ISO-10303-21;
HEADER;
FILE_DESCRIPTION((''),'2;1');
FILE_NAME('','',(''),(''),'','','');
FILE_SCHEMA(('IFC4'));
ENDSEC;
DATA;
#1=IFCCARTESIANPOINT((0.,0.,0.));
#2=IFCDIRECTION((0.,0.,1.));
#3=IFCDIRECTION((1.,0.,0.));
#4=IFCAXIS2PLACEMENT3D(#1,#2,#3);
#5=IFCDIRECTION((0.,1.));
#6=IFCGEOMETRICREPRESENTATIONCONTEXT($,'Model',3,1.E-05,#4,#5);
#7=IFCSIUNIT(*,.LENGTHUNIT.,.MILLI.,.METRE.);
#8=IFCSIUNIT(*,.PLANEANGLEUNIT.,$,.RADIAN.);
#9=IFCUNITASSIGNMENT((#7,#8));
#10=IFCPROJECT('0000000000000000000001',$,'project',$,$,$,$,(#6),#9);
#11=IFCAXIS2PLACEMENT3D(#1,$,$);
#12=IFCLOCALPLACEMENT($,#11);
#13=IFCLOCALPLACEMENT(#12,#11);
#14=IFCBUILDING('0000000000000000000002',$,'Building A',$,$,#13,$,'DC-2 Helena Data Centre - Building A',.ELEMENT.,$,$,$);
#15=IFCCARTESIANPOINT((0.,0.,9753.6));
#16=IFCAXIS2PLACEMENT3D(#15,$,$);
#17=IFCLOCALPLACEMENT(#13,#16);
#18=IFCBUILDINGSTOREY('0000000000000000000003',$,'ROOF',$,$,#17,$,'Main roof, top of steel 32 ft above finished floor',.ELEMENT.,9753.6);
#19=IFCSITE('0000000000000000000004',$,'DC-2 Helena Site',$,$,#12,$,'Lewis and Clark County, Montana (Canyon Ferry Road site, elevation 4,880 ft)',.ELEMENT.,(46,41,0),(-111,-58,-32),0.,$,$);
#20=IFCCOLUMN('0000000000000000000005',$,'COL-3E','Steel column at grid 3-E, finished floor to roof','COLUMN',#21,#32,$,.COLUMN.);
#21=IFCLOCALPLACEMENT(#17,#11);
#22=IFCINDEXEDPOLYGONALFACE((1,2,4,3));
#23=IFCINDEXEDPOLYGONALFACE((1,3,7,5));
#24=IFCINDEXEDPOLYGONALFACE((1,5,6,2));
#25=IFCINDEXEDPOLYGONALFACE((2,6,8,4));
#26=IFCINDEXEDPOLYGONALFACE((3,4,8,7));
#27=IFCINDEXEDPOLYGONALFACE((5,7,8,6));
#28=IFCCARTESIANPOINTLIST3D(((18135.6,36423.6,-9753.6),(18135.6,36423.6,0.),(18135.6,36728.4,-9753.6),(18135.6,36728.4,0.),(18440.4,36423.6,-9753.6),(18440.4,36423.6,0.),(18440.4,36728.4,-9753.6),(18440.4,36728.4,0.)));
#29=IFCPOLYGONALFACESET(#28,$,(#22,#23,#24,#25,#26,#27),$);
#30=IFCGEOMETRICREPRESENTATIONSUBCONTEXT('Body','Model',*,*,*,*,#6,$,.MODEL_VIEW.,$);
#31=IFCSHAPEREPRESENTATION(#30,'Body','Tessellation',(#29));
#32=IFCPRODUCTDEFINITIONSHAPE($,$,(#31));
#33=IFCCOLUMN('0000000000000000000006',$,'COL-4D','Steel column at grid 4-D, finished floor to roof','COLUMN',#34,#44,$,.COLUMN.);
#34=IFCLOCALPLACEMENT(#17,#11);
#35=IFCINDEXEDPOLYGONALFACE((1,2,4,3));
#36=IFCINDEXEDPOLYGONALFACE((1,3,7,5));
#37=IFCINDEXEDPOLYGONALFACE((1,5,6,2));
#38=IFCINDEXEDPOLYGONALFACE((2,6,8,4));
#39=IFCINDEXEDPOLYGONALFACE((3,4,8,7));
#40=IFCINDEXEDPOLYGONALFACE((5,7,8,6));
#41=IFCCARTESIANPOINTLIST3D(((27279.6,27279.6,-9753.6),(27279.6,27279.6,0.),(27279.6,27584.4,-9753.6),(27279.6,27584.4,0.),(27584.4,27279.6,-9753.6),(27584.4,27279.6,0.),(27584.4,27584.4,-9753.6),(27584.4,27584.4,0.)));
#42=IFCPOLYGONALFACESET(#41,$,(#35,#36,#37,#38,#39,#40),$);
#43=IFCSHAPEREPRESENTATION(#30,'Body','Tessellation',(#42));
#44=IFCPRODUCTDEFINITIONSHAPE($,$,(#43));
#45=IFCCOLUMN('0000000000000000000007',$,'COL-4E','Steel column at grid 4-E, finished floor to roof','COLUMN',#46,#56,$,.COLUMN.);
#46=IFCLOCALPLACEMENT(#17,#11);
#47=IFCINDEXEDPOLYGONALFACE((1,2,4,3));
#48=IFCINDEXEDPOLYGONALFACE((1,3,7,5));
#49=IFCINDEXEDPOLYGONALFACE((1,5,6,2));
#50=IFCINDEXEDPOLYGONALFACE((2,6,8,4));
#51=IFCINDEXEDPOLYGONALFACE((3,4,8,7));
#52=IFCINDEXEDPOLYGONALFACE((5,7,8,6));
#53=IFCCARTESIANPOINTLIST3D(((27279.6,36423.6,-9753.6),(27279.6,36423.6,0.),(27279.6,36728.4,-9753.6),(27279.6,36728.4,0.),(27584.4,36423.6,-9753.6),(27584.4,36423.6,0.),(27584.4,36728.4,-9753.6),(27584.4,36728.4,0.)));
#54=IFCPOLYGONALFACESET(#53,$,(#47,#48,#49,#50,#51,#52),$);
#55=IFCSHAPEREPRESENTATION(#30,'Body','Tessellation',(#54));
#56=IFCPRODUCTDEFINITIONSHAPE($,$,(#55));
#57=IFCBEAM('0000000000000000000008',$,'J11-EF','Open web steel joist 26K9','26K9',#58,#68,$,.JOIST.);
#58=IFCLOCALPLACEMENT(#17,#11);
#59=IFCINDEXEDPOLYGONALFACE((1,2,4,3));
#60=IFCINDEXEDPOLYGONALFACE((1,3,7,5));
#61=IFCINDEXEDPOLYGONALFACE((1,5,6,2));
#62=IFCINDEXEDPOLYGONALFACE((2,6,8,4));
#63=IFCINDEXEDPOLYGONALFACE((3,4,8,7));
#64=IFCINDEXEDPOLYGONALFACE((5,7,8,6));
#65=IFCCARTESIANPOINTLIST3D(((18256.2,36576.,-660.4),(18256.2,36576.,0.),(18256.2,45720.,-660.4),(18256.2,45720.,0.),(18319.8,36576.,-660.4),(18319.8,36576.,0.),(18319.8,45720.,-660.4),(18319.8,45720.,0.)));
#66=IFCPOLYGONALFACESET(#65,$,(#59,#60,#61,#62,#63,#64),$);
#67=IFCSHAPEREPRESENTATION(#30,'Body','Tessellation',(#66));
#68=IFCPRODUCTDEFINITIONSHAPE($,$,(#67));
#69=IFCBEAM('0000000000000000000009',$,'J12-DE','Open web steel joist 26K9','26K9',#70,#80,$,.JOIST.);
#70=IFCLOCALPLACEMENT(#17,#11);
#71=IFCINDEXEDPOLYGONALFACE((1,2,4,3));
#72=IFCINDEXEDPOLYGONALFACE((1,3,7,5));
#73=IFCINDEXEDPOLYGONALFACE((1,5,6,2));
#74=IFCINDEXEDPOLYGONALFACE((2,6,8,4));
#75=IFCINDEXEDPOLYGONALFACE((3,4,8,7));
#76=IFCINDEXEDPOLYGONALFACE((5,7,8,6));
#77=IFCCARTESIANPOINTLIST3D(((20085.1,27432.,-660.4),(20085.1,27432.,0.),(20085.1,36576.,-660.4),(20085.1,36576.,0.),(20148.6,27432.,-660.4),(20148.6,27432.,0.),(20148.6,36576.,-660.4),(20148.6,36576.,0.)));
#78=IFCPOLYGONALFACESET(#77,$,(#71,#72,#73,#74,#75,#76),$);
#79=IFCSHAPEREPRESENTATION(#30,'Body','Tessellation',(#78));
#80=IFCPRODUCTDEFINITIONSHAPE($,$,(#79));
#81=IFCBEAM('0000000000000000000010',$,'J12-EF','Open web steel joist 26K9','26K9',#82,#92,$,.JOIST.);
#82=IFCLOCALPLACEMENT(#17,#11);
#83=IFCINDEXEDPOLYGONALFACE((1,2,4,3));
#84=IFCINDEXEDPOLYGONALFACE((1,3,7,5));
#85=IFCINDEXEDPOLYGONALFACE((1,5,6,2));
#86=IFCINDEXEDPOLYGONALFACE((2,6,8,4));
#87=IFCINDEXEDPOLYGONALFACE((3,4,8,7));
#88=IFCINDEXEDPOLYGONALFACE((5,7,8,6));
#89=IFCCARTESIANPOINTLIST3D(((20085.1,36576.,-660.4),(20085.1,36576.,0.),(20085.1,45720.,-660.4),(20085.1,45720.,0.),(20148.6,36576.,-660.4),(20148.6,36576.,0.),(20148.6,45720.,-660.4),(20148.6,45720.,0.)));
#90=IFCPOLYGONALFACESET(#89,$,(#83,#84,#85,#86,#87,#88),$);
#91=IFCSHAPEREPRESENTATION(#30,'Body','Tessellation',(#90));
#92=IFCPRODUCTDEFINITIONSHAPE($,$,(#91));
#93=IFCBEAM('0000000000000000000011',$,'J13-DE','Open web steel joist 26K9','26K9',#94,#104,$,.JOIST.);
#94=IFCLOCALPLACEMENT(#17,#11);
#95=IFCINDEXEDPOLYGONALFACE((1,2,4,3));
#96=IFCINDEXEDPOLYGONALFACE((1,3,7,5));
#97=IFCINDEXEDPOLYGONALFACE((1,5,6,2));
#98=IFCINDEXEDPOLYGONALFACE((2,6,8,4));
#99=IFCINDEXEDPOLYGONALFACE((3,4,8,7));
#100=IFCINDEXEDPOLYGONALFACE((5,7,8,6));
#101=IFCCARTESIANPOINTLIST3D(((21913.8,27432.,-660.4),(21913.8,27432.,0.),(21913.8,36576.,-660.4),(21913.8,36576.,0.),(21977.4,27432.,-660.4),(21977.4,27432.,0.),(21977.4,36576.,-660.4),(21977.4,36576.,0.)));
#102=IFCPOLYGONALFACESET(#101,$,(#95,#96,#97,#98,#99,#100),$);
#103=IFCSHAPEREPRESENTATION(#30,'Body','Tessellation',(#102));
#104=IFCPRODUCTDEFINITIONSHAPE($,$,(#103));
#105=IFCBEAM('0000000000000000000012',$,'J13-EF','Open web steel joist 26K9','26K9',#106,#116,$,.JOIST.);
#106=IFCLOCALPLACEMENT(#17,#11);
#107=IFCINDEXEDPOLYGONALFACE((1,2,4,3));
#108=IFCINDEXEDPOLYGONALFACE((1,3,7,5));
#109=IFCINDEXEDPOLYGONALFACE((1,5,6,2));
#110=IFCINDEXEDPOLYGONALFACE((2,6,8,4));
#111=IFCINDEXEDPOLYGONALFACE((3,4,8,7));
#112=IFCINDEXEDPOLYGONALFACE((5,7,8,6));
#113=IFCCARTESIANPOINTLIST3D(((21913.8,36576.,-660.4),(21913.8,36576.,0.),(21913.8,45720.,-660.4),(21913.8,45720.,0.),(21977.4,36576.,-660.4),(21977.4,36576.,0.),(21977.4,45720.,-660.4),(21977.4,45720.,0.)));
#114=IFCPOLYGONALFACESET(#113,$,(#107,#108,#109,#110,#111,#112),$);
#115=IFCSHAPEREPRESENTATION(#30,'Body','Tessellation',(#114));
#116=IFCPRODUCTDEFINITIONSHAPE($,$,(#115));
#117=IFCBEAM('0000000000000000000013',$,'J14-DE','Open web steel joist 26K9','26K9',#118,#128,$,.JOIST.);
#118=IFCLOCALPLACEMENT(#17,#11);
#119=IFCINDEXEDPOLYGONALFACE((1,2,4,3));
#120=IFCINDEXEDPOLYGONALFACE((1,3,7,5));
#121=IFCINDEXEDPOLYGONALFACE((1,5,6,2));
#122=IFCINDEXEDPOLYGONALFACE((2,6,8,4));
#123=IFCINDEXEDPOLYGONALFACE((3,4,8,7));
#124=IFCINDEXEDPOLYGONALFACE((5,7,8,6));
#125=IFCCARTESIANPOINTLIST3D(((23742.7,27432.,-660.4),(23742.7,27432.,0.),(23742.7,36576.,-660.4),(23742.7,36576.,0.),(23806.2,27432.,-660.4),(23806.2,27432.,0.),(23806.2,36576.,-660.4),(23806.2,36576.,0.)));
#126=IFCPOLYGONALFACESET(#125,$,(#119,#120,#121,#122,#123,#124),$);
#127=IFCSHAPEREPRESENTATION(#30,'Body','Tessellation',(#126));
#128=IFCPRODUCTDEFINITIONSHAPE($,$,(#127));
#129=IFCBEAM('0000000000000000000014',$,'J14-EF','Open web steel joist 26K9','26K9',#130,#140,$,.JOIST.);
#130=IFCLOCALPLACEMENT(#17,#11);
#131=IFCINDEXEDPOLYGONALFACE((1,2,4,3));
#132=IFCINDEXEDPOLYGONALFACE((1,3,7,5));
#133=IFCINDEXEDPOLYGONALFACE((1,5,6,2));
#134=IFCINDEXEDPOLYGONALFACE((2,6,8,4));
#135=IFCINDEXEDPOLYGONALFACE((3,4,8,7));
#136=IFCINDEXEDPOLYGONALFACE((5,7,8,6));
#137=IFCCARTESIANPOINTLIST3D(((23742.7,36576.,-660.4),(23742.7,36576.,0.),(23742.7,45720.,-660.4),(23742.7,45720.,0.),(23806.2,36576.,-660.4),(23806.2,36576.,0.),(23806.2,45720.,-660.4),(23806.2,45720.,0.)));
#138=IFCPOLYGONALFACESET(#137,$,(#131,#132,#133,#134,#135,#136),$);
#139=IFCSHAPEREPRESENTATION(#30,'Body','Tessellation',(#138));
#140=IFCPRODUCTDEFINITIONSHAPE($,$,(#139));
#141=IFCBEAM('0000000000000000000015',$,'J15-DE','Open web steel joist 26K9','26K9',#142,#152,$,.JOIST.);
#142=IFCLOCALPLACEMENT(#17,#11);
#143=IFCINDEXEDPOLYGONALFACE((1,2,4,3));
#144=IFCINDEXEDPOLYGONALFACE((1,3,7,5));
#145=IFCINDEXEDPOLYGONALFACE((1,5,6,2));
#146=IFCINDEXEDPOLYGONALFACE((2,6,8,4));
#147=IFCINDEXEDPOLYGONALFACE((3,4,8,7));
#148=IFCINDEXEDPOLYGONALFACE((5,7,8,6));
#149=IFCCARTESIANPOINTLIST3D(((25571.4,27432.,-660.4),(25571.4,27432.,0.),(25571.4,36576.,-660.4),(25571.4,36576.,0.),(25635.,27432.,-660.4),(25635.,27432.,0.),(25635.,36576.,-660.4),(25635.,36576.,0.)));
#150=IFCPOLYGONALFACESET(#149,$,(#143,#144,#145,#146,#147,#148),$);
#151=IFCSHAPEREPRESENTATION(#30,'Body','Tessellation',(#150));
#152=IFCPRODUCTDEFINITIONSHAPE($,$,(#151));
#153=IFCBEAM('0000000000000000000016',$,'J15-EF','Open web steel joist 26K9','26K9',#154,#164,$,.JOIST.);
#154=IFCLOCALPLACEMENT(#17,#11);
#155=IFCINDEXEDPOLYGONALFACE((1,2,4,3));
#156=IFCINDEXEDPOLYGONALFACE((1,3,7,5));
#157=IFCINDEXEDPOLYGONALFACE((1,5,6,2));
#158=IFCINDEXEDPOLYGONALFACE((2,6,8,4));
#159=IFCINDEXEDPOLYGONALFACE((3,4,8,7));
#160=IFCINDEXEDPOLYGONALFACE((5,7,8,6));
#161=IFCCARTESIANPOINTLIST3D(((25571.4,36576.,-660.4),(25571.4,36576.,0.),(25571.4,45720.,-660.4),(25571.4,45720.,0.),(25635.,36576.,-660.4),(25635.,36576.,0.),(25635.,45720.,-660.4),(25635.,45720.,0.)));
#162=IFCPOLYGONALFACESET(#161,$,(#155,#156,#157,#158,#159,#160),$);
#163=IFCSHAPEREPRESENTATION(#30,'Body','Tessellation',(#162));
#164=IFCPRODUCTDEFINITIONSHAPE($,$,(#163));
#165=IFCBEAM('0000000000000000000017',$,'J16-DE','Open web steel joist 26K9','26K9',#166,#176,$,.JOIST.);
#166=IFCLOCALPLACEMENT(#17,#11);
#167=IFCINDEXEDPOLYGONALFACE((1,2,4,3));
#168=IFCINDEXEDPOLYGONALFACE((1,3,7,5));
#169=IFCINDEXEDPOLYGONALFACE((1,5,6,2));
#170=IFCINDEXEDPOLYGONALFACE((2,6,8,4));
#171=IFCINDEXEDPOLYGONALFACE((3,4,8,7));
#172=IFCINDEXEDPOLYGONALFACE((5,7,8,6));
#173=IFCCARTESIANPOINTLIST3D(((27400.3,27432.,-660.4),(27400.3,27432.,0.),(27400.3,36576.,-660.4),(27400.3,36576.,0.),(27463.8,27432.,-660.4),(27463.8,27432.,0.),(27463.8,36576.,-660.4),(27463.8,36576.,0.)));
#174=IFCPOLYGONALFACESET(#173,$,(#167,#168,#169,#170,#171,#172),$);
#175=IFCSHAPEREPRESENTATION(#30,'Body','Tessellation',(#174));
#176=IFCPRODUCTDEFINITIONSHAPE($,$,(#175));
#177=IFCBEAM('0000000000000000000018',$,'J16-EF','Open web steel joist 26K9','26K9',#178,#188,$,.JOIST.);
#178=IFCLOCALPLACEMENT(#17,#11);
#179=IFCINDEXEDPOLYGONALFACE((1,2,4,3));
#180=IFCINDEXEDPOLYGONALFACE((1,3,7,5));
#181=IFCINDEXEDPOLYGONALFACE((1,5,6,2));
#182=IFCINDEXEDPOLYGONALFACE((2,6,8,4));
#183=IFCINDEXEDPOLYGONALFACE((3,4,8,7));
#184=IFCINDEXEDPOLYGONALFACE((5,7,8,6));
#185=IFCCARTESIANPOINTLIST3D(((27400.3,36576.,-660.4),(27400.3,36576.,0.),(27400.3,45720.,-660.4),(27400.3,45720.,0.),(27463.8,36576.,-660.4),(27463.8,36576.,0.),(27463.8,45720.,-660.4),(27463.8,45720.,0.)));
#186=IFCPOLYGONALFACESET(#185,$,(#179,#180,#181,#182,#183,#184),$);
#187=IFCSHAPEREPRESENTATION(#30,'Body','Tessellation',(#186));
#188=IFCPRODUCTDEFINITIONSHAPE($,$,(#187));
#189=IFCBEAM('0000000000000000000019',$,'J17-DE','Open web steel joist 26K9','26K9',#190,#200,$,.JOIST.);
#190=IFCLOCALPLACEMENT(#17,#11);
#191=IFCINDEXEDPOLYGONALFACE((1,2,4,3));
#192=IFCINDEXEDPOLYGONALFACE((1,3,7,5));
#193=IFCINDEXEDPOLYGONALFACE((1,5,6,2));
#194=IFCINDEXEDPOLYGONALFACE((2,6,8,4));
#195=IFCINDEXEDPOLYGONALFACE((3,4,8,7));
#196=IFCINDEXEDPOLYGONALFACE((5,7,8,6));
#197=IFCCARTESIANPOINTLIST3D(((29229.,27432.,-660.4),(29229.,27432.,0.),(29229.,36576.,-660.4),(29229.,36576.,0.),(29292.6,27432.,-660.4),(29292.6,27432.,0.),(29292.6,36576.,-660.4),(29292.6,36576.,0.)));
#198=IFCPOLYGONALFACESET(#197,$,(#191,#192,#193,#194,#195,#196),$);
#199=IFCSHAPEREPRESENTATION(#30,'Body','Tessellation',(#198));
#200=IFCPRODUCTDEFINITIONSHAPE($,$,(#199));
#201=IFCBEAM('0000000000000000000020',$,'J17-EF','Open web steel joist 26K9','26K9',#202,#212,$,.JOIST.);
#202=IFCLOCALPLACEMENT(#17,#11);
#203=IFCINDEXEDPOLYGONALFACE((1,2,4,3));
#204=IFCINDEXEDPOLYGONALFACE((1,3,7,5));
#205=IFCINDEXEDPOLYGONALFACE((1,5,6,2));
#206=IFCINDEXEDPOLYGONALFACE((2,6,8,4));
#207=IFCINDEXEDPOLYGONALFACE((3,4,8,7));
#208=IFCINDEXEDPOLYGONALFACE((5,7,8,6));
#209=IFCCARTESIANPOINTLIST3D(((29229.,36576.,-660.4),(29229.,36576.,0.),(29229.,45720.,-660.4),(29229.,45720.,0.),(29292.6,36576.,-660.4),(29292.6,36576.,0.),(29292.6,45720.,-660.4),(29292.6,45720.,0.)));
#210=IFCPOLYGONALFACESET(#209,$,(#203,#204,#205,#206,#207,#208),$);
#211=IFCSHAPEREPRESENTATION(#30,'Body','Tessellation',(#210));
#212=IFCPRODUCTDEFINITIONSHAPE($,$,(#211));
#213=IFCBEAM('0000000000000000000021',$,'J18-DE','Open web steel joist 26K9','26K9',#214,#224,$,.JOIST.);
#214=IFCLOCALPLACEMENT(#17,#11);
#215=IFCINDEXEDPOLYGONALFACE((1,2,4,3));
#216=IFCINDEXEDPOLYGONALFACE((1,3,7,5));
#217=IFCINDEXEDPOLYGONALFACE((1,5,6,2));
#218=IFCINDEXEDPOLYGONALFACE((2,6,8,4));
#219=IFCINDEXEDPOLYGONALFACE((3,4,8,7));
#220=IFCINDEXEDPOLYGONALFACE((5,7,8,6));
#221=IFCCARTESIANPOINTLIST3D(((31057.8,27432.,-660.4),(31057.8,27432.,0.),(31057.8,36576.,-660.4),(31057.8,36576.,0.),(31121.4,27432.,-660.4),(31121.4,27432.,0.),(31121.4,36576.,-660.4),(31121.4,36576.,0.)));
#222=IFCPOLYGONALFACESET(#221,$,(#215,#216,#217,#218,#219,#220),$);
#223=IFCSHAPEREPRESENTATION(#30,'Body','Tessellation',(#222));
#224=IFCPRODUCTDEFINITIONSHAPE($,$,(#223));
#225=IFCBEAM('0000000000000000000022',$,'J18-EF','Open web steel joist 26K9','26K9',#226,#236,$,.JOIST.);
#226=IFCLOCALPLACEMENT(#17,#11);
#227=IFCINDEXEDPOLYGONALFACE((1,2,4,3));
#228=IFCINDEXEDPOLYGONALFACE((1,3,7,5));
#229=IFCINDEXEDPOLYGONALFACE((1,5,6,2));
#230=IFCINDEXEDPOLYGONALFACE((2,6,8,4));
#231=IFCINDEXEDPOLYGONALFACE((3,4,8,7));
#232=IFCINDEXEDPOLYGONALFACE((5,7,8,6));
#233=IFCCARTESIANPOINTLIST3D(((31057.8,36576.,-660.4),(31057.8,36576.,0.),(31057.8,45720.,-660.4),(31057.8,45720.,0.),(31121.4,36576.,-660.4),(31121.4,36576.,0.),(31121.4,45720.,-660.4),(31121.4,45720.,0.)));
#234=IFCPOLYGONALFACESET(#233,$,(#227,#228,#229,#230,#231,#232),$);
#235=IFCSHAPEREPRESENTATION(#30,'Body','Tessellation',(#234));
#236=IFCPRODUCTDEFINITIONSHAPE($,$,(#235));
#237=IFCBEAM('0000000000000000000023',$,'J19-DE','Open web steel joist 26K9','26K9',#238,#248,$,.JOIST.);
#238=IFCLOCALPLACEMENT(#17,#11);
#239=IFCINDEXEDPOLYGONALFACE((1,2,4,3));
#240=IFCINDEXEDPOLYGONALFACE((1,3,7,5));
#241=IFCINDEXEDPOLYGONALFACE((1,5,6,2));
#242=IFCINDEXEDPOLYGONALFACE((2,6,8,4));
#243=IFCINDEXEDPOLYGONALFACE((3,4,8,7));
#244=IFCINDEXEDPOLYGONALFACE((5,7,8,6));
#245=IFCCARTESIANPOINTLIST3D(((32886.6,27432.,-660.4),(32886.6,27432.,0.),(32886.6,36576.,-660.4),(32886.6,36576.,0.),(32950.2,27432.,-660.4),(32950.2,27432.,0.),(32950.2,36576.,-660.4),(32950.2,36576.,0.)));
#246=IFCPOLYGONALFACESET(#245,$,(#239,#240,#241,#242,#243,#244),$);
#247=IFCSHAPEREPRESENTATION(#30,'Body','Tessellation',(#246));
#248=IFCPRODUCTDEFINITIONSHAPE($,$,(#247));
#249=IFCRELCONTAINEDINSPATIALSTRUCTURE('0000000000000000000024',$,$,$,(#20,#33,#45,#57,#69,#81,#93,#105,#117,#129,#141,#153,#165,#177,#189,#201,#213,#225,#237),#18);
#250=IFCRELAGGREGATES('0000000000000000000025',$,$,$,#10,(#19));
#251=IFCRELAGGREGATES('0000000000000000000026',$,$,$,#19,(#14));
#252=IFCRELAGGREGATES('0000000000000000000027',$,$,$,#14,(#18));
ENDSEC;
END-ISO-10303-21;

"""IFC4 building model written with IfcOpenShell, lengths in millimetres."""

from ifc_helpers import new_model, si_unit, direction, frame, origin, origin_with_axes, origin_2d, place, context, subcontext, project, spatial, rectangle, extrude, element, save


model = new_model("IFC4")

# Units and contexts
model_context = context("Model", 3, precision=1e-05, world=origin_with_axes(), true_north=direction((0.0, 1.0)))
body_context = subcontext(model_context, "Body", "Model", "MODEL_VIEW")
ifc_project = project(units=[si_unit("LENGTHUNIT", "METRE", prefix="MILLI"), si_unit("PLANEANGLEUNIT", "RADIAN")], contexts=[model_context])

# Site, building, storey
site_placement = place(None, origin())
site = spatial("IfcSite", under=ifc_project, at=site_placement, Name="DC-2 Helena Site", LongName="Lewis and Clark County, Montana (Canyon Ferry Road site, elevation 4,880 ft)", CompositionType="ELEMENT", RefLatitude=(46, 41, 0), RefLongitude=(-111, -58, -32), RefElevation=0.0)
building_placement = place(site_placement, origin())
building = spatial("IfcBuilding", under=site, at=building_placement, Name="Building A", LongName="DC-2 Helena Data Centre - Building A", CompositionType="ELEMENT")
storey_placement = place(building_placement, frame((0.0, 0.0, 9753.6)))
storey = spatial("IfcBuildingStorey", under=building, at=storey_placement, Name="ROOF", LongName="Main roof, top of steel 32 ft above finished floor", CompositionType="ELEMENT", Elevation=9753.6)

# Columns
for number, where, name, description in (
    (1, (18288.0, 36576.0, -9753.6), "COL-3E", "Steel column at grid 3-E, finished floor to roof"),
    (2, (27432.0, 27432.0, -9753.6), "COL-4D", "Steel column at grid 4-D, finished floor to roof"),
    (3, (27432.0, 36576.0, -9753.6), "COL-4E", "Steel column at grid 4-E, finished floor to roof"),
):
    element("IfcColumn", number, at=place(storey_placement, frame(where)), inside=storey, Name=name, Description=description, ObjectType="COLUMN", PredefinedType="COLUMN", context=body_context, shape_type="SweptSolid", body=[
        extrude(rectangle(XDim=304.8, YDim=304.8, at=origin_2d()), origin(), (0.0, 0.0, 1.0), 9753.6),
    ])

# Beams
placement_1 = place(storey_placement, frame((18288.0, 36576.0, 0.0)))
element("IfcBeam", 4, at=placement_1, inside=storey, Name="J11-EF", Description="Open web steel joist 26K9", ObjectType="26K9", PredefinedType="JOIST", context=body_context, shape_type="SweptSolid", body=[
    extrude(rectangle(XDim=63.5, YDim=660.4, at=origin_2d()), frame((0.0, 0.0, -330.2), z_axis=(0.0, 1.0, 0.0), x_axis=(1.0, 0.0, 0.0)), (0.0, 0.0, 1.0), 9144.0),
])
for number, where, name in (
    (5, (20116.8, 27432.0, 0.0), "J12-DE"),
    (6, (20116.8, 36576.0, 0.0), "J12-EF"),
    (7, (21945.6, 27432.0, 0.0), "J13-DE"),
    (8, (21945.6, 36576.0, 0.0), "J13-EF"),
    (9, (23774.4, 27432.0, 0.0), "J14-DE"),
    (10, (23774.4, 36576.0, 0.0), "J14-EF"),
    (11, (25603.2, 27432.0, 0.0), "J15-DE"),
    (12, (25603.2, 36576.0, 0.0), "J15-EF"),
):
    element("IfcBeam", number, at=place(storey_placement, frame(where)), inside=storey, Name=name, Description="Open web steel joist 26K9", ObjectType="26K9", PredefinedType="JOIST", context=body_context, shape_type="SweptSolid", body=[
        extrude(rectangle(XDim=63.5, YDim=660.4, at=origin_2d()), frame((0.0, 0.0, -330.2), z_axis=(0.0, 1.0, 0.0), x_axis=(1.0, 0.0, 0.0)), (0.0, 0.0, 1.0), 9144.0),
    ])
placement_2 = place(storey_placement, frame((27432.0, 27432.0, 0.0)))
element("IfcBeam", 13, at=placement_2, inside=storey, Name="J16-DE", Description="Open web steel joist 26K9", ObjectType="26K9", PredefinedType="JOIST", context=body_context, shape_type="SweptSolid", body=[
    extrude(rectangle(XDim=63.5, YDim=660.4, at=origin_2d()), frame((0.0, 0.0, -330.2), z_axis=(0.0, 1.0, 0.0), x_axis=(1.0, 0.0, 0.0)), (0.0, 0.0, 1.0), 9144.0),
])
placement_3 = place(storey_placement, frame((27432.0, 36576.0, 0.0)))
element("IfcBeam", 14, at=placement_3, inside=storey, Name="J16-EF", Description="Open web steel joist 26K9", ObjectType="26K9", PredefinedType="JOIST", context=body_context, shape_type="SweptSolid", body=[
    extrude(rectangle(XDim=63.5, YDim=660.4, at=origin_2d()), frame((0.0, 0.0, -330.2), z_axis=(0.0, 1.0, 0.0), x_axis=(1.0, 0.0, 0.0)), (0.0, 0.0, 1.0), 9144.0),
])
for number, where, name in (
    (15, (29260.8, 27432.0, 0.0), "J17-DE"),
    (16, (29260.8, 36576.0, 0.0), "J17-EF"),
    (17, (31089.6, 27432.0, 0.0), "J18-DE"),
    (18, (31089.6, 36576.0, 0.0), "J18-EF"),
    (19, (32918.4, 27432.0, 0.0), "J19-DE"),
):
    element("IfcBeam", number, at=place(storey_placement, frame(where)), inside=storey, Name=name, Description="Open web steel joist 26K9", ObjectType="26K9", PredefinedType="JOIST", context=body_context, shape_type="SweptSolid", body=[
        extrude(rectangle(XDim=63.5, YDim=660.4, at=origin_2d()), frame((0.0, 0.0, -330.2), z_axis=(0.0, 1.0, 0.0), x_axis=(1.0, 0.0, 0.0)), (0.0, 0.0, 1.0), 9144.0),
    ])

save(model, "model.ifc")
